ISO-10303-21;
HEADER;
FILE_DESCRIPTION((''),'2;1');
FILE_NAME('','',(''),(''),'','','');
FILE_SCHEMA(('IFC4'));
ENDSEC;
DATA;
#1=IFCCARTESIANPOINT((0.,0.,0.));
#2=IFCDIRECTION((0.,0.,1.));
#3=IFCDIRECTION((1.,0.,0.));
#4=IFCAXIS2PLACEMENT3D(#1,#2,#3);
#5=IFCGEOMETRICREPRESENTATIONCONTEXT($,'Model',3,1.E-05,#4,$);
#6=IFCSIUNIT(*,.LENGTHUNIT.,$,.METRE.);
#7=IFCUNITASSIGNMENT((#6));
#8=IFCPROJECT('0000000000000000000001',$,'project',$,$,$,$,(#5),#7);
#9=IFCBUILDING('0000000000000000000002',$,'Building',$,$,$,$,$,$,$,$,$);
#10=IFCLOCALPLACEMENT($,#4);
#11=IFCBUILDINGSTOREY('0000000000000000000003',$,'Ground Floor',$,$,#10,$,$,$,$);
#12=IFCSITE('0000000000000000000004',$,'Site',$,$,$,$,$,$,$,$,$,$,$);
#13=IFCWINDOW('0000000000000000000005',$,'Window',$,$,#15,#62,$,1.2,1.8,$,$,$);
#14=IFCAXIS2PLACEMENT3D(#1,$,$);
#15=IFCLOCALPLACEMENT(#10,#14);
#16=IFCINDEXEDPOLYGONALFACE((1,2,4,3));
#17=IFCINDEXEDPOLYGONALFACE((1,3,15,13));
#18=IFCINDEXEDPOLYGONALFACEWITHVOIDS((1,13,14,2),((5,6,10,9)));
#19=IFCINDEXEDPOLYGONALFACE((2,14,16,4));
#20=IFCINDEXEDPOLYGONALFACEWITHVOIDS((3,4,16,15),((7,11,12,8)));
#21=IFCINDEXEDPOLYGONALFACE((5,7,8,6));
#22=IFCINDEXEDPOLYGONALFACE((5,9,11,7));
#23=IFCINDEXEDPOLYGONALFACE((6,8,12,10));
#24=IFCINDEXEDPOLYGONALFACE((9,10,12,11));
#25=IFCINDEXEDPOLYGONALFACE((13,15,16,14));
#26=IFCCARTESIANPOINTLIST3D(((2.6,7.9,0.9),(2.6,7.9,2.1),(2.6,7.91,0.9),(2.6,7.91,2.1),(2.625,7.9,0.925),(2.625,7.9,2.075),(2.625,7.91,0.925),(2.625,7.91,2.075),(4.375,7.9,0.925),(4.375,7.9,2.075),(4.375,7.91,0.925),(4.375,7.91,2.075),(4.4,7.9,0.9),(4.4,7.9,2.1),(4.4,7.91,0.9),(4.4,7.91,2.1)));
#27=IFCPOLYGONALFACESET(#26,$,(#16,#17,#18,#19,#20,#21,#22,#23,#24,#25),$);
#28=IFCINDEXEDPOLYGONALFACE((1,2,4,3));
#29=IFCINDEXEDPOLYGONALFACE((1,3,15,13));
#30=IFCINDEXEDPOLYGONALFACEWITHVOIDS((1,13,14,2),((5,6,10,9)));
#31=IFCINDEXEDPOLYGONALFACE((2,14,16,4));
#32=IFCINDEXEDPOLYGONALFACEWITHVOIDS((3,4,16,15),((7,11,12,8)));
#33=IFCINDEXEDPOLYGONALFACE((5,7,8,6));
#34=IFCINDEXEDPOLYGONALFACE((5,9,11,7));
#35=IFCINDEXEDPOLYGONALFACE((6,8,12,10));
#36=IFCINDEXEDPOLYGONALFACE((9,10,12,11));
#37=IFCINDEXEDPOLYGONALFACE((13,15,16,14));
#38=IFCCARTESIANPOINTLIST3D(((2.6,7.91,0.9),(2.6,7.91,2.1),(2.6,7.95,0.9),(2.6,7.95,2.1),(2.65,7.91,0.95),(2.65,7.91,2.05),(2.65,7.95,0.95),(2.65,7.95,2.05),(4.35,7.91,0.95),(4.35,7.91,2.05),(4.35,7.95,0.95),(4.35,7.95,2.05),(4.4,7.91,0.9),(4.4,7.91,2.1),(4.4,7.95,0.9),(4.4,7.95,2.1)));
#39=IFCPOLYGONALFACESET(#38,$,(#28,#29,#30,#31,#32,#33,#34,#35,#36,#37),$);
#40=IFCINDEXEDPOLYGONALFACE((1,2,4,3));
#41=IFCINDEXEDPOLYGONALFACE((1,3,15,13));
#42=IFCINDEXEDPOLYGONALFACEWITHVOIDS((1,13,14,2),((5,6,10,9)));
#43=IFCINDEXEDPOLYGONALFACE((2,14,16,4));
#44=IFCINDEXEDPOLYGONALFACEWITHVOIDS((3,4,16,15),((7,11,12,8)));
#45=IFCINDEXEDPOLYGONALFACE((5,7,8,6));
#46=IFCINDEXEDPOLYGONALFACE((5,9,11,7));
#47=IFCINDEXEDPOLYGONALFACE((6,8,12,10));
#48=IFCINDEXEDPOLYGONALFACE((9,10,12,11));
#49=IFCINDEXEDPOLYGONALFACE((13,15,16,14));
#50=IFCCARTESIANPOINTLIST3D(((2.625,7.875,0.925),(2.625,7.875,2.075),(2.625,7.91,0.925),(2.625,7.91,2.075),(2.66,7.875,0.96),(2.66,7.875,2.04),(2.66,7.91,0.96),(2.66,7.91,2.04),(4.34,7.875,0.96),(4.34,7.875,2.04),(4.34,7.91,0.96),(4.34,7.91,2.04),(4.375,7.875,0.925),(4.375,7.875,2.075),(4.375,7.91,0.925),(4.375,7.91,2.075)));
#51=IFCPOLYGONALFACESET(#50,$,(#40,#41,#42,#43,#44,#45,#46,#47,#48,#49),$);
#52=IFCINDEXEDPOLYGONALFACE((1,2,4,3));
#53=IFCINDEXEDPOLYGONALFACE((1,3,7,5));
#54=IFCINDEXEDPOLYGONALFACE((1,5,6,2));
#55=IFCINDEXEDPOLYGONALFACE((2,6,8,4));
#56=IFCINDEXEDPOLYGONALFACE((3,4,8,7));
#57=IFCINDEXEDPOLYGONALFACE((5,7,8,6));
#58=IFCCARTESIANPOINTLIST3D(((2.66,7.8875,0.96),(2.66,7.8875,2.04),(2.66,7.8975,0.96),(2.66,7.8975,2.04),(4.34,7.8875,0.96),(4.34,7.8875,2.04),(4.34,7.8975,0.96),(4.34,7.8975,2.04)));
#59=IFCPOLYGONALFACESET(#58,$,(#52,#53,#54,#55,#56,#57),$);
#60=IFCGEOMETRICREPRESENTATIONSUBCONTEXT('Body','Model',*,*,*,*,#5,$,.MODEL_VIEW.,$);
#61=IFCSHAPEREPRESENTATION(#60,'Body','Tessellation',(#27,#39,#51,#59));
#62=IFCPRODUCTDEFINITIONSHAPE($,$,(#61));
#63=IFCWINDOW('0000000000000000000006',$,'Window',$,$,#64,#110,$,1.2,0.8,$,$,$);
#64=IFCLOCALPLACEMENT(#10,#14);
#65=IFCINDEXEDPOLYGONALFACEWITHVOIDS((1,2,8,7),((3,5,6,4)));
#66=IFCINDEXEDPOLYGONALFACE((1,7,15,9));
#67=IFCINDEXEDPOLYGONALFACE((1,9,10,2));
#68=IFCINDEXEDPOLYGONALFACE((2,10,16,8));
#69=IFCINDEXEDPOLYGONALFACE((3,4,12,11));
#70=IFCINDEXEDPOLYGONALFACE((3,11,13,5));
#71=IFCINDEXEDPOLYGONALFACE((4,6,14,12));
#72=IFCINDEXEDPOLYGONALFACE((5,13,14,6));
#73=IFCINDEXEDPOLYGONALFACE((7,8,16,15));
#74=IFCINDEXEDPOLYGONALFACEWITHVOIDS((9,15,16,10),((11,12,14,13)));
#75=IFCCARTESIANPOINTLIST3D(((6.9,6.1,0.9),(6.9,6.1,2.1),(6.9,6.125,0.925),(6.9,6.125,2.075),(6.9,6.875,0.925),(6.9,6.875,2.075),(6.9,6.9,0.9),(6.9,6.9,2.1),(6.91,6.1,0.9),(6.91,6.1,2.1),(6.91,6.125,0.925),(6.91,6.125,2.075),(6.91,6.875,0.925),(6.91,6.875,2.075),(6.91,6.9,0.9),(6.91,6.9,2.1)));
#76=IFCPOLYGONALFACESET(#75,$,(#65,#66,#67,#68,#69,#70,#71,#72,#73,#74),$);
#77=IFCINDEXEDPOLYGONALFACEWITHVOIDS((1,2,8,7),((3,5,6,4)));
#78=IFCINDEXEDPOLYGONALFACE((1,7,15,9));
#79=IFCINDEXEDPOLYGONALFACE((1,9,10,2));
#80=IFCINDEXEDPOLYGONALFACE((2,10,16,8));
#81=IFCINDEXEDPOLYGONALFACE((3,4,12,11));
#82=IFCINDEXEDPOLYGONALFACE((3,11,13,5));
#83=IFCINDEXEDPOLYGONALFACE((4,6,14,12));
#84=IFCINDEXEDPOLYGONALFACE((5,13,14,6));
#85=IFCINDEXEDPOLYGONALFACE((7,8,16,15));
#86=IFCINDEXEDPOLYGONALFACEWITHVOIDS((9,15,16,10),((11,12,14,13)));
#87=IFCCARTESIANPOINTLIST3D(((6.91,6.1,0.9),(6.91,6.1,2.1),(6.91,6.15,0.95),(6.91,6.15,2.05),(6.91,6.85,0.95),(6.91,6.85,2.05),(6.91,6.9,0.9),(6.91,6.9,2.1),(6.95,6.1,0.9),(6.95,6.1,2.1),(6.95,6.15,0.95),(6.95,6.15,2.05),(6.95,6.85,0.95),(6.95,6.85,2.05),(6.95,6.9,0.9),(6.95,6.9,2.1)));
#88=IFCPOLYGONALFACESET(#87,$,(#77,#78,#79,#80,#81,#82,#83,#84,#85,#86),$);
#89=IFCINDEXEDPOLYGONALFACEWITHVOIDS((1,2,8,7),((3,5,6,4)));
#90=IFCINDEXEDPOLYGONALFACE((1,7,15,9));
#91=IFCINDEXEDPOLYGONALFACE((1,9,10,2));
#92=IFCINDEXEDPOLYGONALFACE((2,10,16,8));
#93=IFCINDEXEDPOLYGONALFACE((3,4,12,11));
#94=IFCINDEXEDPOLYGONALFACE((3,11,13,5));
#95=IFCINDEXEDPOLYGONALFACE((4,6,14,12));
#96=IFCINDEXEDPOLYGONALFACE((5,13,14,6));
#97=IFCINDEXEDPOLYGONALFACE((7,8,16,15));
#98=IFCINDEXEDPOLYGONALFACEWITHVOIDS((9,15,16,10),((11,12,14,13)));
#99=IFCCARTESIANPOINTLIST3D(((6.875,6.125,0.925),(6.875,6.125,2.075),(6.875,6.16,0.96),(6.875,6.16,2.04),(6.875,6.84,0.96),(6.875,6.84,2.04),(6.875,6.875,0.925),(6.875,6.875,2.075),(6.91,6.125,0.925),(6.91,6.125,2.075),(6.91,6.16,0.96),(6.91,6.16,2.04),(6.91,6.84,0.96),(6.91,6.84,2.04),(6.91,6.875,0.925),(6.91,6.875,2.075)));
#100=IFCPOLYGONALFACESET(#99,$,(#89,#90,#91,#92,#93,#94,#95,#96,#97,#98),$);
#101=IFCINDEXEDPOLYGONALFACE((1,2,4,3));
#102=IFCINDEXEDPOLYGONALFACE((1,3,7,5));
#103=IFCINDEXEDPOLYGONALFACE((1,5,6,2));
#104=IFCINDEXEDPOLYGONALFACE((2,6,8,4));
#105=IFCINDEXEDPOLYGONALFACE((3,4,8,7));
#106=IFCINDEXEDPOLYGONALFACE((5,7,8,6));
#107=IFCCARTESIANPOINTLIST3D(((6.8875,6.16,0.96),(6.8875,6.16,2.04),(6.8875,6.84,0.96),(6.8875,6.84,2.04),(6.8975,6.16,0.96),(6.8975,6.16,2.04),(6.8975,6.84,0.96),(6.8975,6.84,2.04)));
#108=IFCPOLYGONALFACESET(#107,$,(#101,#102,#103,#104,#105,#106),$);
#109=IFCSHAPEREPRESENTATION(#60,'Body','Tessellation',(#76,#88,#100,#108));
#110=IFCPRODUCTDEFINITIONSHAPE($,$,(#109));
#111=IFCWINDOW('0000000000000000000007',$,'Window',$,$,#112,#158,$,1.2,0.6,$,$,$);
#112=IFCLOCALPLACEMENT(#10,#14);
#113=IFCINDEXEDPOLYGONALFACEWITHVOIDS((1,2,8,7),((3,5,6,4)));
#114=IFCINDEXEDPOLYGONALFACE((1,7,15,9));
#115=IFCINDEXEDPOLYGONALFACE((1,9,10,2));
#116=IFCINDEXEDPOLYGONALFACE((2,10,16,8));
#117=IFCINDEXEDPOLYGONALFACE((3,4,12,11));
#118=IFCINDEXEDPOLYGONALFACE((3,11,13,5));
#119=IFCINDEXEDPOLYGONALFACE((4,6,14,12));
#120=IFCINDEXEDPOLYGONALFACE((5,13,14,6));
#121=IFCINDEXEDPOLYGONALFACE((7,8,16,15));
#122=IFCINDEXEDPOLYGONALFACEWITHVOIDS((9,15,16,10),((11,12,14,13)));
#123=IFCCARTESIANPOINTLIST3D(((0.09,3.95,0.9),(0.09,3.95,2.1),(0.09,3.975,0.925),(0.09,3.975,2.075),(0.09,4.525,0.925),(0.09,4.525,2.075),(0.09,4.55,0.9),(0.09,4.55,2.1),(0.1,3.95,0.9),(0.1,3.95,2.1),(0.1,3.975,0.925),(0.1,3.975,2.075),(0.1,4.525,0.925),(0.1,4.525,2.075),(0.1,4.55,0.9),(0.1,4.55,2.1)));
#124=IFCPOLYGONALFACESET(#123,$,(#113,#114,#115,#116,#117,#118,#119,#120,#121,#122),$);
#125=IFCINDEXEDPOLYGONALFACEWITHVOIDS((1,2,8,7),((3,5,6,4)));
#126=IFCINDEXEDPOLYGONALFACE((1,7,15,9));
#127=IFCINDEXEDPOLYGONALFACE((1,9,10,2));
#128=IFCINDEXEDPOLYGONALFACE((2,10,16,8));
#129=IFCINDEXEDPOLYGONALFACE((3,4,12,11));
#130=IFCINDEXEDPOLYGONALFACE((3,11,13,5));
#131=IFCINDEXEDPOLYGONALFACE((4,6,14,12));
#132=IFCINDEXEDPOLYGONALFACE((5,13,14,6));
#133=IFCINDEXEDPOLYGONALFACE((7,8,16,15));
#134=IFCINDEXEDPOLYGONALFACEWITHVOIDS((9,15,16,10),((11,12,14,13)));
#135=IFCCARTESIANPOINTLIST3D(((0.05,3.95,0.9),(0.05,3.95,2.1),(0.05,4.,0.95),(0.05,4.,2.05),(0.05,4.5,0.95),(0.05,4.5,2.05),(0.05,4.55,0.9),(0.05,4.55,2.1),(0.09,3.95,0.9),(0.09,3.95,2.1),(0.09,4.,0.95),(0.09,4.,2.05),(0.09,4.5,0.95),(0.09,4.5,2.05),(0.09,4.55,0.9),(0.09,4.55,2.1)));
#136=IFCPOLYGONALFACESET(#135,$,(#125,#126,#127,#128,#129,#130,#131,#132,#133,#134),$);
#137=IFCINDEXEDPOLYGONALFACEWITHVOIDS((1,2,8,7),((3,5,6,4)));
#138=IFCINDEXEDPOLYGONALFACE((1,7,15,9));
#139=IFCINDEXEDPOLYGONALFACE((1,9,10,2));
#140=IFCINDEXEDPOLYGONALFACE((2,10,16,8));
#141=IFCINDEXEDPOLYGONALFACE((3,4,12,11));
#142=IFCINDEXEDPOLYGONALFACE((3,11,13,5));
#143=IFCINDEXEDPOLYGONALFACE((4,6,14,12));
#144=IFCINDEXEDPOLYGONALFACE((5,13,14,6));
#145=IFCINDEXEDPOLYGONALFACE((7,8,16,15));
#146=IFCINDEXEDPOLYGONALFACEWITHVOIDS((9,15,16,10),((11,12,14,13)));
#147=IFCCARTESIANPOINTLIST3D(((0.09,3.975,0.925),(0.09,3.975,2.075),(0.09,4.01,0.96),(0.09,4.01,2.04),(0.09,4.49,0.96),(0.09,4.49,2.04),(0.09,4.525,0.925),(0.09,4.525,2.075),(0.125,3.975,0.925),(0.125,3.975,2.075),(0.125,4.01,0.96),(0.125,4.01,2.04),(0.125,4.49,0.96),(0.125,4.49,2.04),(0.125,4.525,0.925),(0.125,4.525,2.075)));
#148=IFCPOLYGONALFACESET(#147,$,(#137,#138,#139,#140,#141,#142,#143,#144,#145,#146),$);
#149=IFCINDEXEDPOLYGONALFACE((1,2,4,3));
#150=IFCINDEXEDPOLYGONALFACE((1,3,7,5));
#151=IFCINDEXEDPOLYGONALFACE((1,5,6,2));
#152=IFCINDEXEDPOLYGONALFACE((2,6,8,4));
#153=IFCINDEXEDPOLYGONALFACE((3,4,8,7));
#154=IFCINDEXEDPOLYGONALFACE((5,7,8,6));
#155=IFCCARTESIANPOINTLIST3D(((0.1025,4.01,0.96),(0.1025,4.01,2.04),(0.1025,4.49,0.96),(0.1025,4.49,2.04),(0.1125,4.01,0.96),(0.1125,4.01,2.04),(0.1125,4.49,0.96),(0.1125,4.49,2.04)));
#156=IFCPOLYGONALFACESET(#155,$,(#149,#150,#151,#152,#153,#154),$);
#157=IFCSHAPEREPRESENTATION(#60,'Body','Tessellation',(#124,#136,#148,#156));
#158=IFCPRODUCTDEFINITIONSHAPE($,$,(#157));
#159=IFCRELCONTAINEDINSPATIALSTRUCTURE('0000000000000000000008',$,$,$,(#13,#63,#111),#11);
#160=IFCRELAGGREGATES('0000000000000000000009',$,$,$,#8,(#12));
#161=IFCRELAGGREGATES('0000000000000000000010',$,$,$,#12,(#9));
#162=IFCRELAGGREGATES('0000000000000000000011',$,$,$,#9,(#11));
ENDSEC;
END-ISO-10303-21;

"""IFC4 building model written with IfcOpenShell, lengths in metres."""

from ifc_helpers import new_model, si_unit, frame, origin_with_axes, place, context, subcontext, project, spatial, line, indexed_curve, outline, extrude, element, save


model = new_model("IFC4")

# Units and contexts
model_context = context("Model", 3, precision=1e-05, world=origin_with_axes())
body_context = subcontext(model_context, "Body", "Model", "MODEL_VIEW")
ifc_project = project(units=[si_unit("LENGTHUNIT", "METRE")], contexts=[model_context])

# Site, building, storey
site = spatial("IfcSite", under=ifc_project, Name="Site")
building = spatial("IfcBuilding", under=site, Name="Building")
storey_placement = place(None, origin_with_axes())
storey = spatial("IfcBuildingStorey", under=building, at=storey_placement, Name="Ground Floor")

# Windows
window_1_placement = place(storey_placement, frame((4.4, 8.0, 0.9), z_axis=(0.0, 0.0, 1.0), x_axis=(-1.0, 0.0, 0.0)))
element("IfcWindow", 1, at=window_1_placement, inside=storey, Name="Window", OverallHeight=1.2, OverallWidth=1.8, context=body_context, shape_type="SweptSolid", body=[
    extrude(outline(indexed_curve([(0.0, 0.0), (1.8, 0.0), (1.8, 1.2), (0.0, 1.2)], segments=[line(1, 2, 3, 4, 1)]), holes=[indexed_curve([(0.025, 0.025), (1.775, 0.025), (1.775, 1.175), (0.025, 1.175)], segments=[line(1, 2, 3, 4, 1)])]), frame((0.0, 0.09, 0.0), z_axis=(0.0, -1.0, 0.0), x_axis=(1.0, 0.0, 0.0)), (0.0, 0.0, -1.0), 0.01),
    extrude(outline(indexed_curve([(0.0, 0.0), (1.8, 0.0), (1.8, 1.2), (0.0, 1.2)], segments=[line(1, 2, 3, 4, 1)]), holes=[indexed_curve([(0.05, 0.05), (1.75, 0.05), (1.75, 1.15), (0.05, 1.15)], segments=[line(1, 2, 3, 4, 1)])]), frame((0.0, 0.05, 0.0), z_axis=(0.0, -1.0, 0.0), x_axis=(1.0, 0.0, 0.0)), (0.0, 0.0, -1.0), 0.04),
    extrude(outline(indexed_curve([(0.0, 0.0), (1.75, 0.0), (1.75, 1.15), (0.0, 1.15)], segments=[line(1, 2, 3, 4, 1)]), holes=[indexed_curve([(0.035, 0.035), (1.715, 0.035), (1.715, 1.115), (0.035, 1.115)], segments=[line(1, 2, 3, 4, 1)])]), frame((0.025, 0.09, 0.025), z_axis=(0.0, -1.0, 0.0), x_axis=(1.0, 0.0, 0.0)), (0.0, 0.0, -1.0), 0.035),
    extrude(outline(indexed_curve([(0.035, 0.035), (1.715, 0.035), (1.715, 1.115), (0.035, 1.115)], segments=[line(1, 2, 3, 4, 1)])), frame((0.025, 0.1025, 0.025), z_axis=(0.0, -1.0, 0.0), x_axis=(1.0, 0.0, 0.0)), (0.0, 0.0, -1.0), 0.01),
])
window_2_placement = place(storey_placement, frame((7.0, 6.1, 0.9), z_axis=(0.0, 0.0, 1.0), x_axis=(0.0, 1.0, 0.0)))
element("IfcWindow", 2, at=window_2_placement, inside=storey, Name="Window", OverallHeight=1.2, OverallWidth=0.8, context=body_context, shape_type="SweptSolid", body=[
    extrude(outline(indexed_curve([(0.0, 0.0), (0.8, 0.0), (0.8, 1.2), (0.0, 1.2)], segments=[line(1, 2, 3, 4, 1)]), holes=[indexed_curve([(0.025, 0.025), (0.775, 0.025), (0.775, 1.175), (0.025, 1.175)], segments=[line(1, 2, 3, 4, 1)])]), frame((0.0, 0.09, 0.0), z_axis=(0.0, -1.0, 0.0), x_axis=(1.0, 0.0, 0.0)), (0.0, 0.0, -1.0), 0.01),
    extrude(outline(indexed_curve([(0.0, 0.0), (0.8, 0.0), (0.8, 1.2), (0.0, 1.2)], segments=[line(1, 2, 3, 4, 1)]), holes=[indexed_curve([(0.05, 0.05), (0.75, 0.05), (0.75, 1.15), (0.05, 1.15)], segments=[line(1, 2, 3, 4, 1)])]), frame((0.0, 0.05, 0.0), z_axis=(0.0, -1.0, 0.0), x_axis=(1.0, 0.0, 0.0)), (0.0, 0.0, -1.0), 0.04),
    extrude(outline(indexed_curve([(0.0, 0.0), (0.75, 0.0), (0.75, 1.15), (0.0, 1.15)], segments=[line(1, 2, 3, 4, 1)]), holes=[indexed_curve([(0.035, 0.035), (0.715, 0.035), (0.715, 1.115), (0.035, 1.115)], segments=[line(1, 2, 3, 4, 1)])]), frame((0.025, 0.09, 0.025), z_axis=(0.0, -1.0, 0.0), x_axis=(1.0, 0.0, 0.0)), (0.0, 0.0, -1.0), 0.035),
    extrude(outline(indexed_curve([(0.035, 0.035), (0.715, 0.035), (0.715, 1.115), (0.035, 1.115)], segments=[line(1, 2, 3, 4, 1)])), frame((0.025, 0.1025, 0.025), z_axis=(0.0, -1.0, 0.0), x_axis=(1.0, 0.0, 0.0)), (0.0, 0.0, -1.0), 0.01),
])
window_3_placement = place(storey_placement, frame((0.0, 4.55, 0.9), z_axis=(0.0, 0.0, 1.0), x_axis=(0.0, -1.0, 0.0)))
element("IfcWindow", 3, at=window_3_placement, inside=storey, Name="Window", OverallHeight=1.2, OverallWidth=0.6, context=body_context, shape_type="SweptSolid", body=[
    extrude(outline(indexed_curve([(0.0, 0.0), (0.6, 0.0), (0.6, 1.2), (0.0, 1.2)], segments=[line(1, 2, 3, 4, 1)]), holes=[indexed_curve([(0.025, 0.025), (0.575, 0.025), (0.575, 1.175), (0.025, 1.175)], segments=[line(1, 2, 3, 4, 1)])]), frame((0.0, 0.09, 0.0), z_axis=(0.0, -1.0, 0.0), x_axis=(1.0, 0.0, 0.0)), (0.0, 0.0, -1.0), 0.01),
    extrude(outline(indexed_curve([(0.0, 0.0), (0.6, 0.0), (0.6, 1.2), (0.0, 1.2)], segments=[line(1, 2, 3, 4, 1)]), holes=[indexed_curve([(0.05, 0.05), (0.55, 0.05), (0.55, 1.15), (0.05, 1.15)], segments=[line(1, 2, 3, 4, 1)])]), frame((0.0, 0.05, 0.0), z_axis=(0.0, -1.0, 0.0), x_axis=(1.0, 0.0, 0.0)), (0.0, 0.0, -1.0), 0.04),
    extrude(outline(indexed_curve([(0.0, 0.0), (0.55, 0.0), (0.55, 1.15), (0.0, 1.15)], segments=[line(1, 2, 3, 4, 1)]), holes=[indexed_curve([(0.035, 0.035), (0.515, 0.035), (0.515, 1.115), (0.035, 1.115)], segments=[line(1, 2, 3, 4, 1)])]), frame((0.025, 0.09, 0.025), z_axis=(0.0, -1.0, 0.0), x_axis=(1.0, 0.0, 0.0)), (0.0, 0.0, -1.0), 0.035),
    extrude(outline(indexed_curve([(0.035, 0.035), (0.515, 0.035), (0.515, 1.115), (0.035, 1.115)], segments=[line(1, 2, 3, 4, 1)])), frame((0.025, 0.1025, 0.025), z_axis=(0.0, -1.0, 0.0), x_axis=(1.0, 0.0, 0.0)), (0.0, 0.0, -1.0), 0.01),
])

save(model, "model.ifc")
